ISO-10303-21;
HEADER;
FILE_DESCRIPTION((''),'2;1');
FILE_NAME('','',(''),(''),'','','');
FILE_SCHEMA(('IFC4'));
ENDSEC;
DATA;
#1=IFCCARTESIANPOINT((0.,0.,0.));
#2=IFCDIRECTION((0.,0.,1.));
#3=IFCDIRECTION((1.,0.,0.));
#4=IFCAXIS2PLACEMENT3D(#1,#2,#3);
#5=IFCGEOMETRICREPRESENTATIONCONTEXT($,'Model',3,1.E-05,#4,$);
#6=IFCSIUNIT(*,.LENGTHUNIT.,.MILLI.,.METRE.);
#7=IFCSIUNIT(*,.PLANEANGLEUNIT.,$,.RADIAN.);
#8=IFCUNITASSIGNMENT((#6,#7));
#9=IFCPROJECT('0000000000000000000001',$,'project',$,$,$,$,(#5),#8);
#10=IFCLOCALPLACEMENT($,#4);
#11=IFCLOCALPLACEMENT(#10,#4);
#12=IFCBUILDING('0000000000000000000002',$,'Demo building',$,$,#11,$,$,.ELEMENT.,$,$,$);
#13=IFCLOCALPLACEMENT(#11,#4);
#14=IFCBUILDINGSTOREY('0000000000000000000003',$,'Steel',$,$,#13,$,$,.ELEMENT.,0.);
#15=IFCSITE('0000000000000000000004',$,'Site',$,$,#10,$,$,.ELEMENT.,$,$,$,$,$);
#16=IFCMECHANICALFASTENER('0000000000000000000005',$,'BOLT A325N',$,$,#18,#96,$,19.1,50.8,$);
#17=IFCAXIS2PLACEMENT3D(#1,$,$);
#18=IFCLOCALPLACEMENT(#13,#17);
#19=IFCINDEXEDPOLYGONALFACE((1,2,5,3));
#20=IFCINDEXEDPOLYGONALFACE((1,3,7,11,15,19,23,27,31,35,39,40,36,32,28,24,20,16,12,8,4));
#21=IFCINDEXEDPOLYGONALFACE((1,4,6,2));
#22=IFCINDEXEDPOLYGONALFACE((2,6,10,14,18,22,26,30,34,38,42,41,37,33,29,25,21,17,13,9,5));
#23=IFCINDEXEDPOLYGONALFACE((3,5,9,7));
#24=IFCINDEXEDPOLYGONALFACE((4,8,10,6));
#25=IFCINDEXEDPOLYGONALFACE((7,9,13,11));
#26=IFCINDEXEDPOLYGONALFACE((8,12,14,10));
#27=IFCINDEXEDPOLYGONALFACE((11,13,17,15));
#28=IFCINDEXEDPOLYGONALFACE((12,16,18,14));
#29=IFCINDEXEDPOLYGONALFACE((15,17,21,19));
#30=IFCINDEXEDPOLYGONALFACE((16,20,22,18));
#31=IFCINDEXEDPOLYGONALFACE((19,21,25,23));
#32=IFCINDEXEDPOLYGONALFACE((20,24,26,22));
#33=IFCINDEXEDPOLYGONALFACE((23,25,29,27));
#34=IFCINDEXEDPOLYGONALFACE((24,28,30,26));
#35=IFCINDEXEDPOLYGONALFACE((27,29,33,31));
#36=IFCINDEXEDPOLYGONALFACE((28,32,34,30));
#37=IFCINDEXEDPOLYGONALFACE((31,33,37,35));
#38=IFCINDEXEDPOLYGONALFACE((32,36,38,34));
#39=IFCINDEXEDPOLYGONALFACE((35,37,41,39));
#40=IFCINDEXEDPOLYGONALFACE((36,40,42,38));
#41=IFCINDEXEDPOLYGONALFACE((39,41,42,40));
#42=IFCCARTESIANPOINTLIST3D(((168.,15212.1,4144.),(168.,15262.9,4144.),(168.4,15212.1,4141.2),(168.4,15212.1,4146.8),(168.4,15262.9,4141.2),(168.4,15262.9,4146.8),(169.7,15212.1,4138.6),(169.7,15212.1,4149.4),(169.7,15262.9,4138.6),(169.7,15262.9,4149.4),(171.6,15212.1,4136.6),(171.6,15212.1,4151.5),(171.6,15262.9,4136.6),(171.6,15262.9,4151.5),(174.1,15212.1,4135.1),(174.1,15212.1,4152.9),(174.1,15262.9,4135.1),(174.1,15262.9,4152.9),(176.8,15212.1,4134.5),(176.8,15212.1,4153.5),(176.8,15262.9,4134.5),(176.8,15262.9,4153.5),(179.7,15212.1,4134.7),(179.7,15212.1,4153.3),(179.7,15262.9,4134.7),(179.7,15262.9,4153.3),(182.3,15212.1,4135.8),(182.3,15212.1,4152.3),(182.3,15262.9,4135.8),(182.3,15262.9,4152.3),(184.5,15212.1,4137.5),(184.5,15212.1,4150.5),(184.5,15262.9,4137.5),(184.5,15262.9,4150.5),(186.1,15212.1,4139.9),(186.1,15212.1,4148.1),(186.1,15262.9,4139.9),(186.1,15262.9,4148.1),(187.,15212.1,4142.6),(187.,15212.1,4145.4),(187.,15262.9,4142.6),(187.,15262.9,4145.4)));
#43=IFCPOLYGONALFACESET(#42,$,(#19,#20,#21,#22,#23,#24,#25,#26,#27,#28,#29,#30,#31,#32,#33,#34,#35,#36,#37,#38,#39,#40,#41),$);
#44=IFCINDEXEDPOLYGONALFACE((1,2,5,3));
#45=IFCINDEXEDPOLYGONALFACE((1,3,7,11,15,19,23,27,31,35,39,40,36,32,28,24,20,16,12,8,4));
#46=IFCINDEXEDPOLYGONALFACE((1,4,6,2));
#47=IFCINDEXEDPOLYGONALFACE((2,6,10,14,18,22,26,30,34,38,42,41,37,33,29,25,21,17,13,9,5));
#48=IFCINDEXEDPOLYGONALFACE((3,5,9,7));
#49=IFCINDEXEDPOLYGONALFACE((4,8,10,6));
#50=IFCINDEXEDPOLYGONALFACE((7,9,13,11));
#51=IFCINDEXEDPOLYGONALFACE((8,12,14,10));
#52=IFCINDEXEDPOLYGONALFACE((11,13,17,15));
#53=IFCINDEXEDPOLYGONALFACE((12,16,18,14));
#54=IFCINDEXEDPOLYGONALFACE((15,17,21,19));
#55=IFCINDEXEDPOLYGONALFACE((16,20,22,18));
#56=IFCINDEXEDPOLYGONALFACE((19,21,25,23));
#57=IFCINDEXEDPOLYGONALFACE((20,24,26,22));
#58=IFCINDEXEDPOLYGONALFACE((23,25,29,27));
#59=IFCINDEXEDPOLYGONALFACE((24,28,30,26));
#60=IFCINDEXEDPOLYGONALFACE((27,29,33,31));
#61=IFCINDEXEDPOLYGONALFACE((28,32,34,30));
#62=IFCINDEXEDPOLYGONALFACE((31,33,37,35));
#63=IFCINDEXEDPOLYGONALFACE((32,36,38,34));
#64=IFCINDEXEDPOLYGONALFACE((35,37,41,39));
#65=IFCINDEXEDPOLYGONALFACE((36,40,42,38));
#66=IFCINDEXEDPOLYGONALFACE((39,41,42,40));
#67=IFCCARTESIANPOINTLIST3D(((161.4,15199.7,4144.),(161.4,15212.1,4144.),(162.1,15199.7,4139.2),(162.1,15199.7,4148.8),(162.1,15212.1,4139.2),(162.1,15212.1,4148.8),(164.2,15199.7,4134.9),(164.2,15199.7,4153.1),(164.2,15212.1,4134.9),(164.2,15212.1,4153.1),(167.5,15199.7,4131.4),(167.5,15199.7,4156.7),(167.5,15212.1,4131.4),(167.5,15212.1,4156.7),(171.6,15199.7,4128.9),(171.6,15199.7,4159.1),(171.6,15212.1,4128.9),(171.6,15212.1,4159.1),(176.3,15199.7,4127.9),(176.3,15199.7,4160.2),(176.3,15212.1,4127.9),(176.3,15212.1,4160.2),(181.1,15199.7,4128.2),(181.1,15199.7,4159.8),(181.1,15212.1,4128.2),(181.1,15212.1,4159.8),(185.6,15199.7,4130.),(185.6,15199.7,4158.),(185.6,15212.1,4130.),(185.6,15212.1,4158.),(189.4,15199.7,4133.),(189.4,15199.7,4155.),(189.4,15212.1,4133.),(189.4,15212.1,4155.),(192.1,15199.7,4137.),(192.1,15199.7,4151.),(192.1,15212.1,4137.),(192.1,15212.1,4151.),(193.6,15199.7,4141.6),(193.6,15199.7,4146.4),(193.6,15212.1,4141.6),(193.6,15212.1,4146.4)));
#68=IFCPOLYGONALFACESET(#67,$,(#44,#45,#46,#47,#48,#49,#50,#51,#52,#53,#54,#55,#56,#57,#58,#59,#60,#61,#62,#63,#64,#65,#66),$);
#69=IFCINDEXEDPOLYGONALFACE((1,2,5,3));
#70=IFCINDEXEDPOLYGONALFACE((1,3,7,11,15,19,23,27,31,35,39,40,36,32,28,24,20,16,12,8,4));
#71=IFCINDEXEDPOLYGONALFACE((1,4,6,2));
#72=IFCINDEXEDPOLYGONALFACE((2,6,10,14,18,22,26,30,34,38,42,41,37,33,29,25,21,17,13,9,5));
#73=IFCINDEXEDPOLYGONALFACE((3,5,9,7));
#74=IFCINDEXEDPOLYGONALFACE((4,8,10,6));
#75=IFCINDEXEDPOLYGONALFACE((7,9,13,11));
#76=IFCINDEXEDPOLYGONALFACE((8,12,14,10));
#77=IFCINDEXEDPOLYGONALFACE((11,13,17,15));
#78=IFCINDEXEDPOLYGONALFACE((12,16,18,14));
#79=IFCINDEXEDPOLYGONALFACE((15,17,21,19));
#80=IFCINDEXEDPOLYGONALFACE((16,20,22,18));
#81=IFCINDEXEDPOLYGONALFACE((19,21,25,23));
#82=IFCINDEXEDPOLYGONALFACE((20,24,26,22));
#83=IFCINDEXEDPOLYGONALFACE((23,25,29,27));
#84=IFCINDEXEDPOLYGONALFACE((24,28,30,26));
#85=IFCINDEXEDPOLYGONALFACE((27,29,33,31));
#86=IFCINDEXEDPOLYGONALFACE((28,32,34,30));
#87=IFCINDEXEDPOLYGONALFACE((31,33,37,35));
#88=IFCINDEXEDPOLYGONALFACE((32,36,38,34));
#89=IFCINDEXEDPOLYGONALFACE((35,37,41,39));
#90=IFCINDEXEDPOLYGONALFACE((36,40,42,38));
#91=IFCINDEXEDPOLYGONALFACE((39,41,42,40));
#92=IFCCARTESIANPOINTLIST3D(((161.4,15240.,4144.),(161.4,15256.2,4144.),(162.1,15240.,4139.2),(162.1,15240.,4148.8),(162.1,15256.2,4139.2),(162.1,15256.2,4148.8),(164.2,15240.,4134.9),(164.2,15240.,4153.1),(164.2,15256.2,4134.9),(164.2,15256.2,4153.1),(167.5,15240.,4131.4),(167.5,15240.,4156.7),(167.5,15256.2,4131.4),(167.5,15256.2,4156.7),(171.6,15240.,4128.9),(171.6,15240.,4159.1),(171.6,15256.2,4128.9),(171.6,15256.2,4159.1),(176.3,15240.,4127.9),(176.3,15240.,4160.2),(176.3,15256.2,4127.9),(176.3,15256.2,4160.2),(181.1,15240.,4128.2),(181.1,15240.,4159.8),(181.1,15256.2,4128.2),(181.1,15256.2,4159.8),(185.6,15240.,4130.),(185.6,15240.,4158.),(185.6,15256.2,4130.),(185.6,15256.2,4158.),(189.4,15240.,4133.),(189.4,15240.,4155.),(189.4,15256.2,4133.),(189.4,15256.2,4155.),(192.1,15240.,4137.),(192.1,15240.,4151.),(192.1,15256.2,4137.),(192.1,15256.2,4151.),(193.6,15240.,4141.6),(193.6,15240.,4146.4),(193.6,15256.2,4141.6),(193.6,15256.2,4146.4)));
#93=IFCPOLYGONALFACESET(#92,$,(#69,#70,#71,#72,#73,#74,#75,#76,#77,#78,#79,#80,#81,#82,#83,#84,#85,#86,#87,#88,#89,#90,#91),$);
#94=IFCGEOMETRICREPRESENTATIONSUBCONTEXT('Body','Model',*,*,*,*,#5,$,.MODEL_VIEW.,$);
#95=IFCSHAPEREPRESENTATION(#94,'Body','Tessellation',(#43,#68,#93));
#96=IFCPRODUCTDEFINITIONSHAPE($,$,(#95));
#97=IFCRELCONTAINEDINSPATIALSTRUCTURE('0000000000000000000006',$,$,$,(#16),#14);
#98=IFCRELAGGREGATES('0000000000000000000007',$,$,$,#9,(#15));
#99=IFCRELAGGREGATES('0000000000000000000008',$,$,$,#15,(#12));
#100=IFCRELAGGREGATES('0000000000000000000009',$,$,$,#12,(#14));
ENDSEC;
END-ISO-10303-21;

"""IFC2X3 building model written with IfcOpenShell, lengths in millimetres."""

from ifc_helpers import new_model, si_unit, frame, origin, origin_with_axes, origin_2d, place, context, subcontext, project, spatial, circle, extrude, element, save


model = new_model("IFC2X3")

# Units and contexts
model_context = context("Model", 3, precision=1e-05, world=origin_with_axes())
body_context = subcontext(model_context, "Body", "Model", "MODEL_VIEW")
ifc_project = project(units=[si_unit("LENGTHUNIT", "METRE", prefix="MILLI"), si_unit("PLANEANGLEUNIT", "RADIAN")], contexts=[model_context])

# Site, building, storey
site_placement = place(None, origin_with_axes())
site = spatial("IfcSite", under=ifc_project, at=site_placement, Name="Site", CompositionType="ELEMENT")
building_placement = place(site_placement, origin_with_axes())
building = spatial("IfcBuilding", under=site, at=building_placement, Name="Demo building", CompositionType="ELEMENT")
placement = place(building_placement, origin_with_axes())
storey = spatial("IfcBuildingStorey", under=building, at=placement, Name="Steel", CompositionType="ELEMENT", Elevation=0.0)

# Mechanical fastener
for number, where, z_axis, x_axis, name in (
    (1, (177.5, 15212.1, 4144.0), (0.0, 1.0, 0.0), (-1.0, 0.0, 0.0), "BOLT A325N"),
):
    element("IfcMechanicalFastener", number, at=place(placement, frame(where, z_axis=z_axis, x_axis=x_axis)), inside=storey, Name=name, NominalDiameter=19.1, NominalLength=50.8, context=body_context, shape_type="SweptSolid", body=[
        extrude(circle(Radius=9.5, at=origin_2d()), origin(), (0.0, 0.0, 1.0), 50.8),
        extrude(circle(Radius=16.2, at=origin_2d()), frame((0.0, 0.0, -12.4)), (0.0, 0.0, 1.0), 12.4),
        extrude(circle(Radius=16.2, at=origin_2d()), frame((0.0, 0.0, 27.9)), (0.0, 0.0, 1.0), 16.2),
    ])

save(model, "model.ifc")
